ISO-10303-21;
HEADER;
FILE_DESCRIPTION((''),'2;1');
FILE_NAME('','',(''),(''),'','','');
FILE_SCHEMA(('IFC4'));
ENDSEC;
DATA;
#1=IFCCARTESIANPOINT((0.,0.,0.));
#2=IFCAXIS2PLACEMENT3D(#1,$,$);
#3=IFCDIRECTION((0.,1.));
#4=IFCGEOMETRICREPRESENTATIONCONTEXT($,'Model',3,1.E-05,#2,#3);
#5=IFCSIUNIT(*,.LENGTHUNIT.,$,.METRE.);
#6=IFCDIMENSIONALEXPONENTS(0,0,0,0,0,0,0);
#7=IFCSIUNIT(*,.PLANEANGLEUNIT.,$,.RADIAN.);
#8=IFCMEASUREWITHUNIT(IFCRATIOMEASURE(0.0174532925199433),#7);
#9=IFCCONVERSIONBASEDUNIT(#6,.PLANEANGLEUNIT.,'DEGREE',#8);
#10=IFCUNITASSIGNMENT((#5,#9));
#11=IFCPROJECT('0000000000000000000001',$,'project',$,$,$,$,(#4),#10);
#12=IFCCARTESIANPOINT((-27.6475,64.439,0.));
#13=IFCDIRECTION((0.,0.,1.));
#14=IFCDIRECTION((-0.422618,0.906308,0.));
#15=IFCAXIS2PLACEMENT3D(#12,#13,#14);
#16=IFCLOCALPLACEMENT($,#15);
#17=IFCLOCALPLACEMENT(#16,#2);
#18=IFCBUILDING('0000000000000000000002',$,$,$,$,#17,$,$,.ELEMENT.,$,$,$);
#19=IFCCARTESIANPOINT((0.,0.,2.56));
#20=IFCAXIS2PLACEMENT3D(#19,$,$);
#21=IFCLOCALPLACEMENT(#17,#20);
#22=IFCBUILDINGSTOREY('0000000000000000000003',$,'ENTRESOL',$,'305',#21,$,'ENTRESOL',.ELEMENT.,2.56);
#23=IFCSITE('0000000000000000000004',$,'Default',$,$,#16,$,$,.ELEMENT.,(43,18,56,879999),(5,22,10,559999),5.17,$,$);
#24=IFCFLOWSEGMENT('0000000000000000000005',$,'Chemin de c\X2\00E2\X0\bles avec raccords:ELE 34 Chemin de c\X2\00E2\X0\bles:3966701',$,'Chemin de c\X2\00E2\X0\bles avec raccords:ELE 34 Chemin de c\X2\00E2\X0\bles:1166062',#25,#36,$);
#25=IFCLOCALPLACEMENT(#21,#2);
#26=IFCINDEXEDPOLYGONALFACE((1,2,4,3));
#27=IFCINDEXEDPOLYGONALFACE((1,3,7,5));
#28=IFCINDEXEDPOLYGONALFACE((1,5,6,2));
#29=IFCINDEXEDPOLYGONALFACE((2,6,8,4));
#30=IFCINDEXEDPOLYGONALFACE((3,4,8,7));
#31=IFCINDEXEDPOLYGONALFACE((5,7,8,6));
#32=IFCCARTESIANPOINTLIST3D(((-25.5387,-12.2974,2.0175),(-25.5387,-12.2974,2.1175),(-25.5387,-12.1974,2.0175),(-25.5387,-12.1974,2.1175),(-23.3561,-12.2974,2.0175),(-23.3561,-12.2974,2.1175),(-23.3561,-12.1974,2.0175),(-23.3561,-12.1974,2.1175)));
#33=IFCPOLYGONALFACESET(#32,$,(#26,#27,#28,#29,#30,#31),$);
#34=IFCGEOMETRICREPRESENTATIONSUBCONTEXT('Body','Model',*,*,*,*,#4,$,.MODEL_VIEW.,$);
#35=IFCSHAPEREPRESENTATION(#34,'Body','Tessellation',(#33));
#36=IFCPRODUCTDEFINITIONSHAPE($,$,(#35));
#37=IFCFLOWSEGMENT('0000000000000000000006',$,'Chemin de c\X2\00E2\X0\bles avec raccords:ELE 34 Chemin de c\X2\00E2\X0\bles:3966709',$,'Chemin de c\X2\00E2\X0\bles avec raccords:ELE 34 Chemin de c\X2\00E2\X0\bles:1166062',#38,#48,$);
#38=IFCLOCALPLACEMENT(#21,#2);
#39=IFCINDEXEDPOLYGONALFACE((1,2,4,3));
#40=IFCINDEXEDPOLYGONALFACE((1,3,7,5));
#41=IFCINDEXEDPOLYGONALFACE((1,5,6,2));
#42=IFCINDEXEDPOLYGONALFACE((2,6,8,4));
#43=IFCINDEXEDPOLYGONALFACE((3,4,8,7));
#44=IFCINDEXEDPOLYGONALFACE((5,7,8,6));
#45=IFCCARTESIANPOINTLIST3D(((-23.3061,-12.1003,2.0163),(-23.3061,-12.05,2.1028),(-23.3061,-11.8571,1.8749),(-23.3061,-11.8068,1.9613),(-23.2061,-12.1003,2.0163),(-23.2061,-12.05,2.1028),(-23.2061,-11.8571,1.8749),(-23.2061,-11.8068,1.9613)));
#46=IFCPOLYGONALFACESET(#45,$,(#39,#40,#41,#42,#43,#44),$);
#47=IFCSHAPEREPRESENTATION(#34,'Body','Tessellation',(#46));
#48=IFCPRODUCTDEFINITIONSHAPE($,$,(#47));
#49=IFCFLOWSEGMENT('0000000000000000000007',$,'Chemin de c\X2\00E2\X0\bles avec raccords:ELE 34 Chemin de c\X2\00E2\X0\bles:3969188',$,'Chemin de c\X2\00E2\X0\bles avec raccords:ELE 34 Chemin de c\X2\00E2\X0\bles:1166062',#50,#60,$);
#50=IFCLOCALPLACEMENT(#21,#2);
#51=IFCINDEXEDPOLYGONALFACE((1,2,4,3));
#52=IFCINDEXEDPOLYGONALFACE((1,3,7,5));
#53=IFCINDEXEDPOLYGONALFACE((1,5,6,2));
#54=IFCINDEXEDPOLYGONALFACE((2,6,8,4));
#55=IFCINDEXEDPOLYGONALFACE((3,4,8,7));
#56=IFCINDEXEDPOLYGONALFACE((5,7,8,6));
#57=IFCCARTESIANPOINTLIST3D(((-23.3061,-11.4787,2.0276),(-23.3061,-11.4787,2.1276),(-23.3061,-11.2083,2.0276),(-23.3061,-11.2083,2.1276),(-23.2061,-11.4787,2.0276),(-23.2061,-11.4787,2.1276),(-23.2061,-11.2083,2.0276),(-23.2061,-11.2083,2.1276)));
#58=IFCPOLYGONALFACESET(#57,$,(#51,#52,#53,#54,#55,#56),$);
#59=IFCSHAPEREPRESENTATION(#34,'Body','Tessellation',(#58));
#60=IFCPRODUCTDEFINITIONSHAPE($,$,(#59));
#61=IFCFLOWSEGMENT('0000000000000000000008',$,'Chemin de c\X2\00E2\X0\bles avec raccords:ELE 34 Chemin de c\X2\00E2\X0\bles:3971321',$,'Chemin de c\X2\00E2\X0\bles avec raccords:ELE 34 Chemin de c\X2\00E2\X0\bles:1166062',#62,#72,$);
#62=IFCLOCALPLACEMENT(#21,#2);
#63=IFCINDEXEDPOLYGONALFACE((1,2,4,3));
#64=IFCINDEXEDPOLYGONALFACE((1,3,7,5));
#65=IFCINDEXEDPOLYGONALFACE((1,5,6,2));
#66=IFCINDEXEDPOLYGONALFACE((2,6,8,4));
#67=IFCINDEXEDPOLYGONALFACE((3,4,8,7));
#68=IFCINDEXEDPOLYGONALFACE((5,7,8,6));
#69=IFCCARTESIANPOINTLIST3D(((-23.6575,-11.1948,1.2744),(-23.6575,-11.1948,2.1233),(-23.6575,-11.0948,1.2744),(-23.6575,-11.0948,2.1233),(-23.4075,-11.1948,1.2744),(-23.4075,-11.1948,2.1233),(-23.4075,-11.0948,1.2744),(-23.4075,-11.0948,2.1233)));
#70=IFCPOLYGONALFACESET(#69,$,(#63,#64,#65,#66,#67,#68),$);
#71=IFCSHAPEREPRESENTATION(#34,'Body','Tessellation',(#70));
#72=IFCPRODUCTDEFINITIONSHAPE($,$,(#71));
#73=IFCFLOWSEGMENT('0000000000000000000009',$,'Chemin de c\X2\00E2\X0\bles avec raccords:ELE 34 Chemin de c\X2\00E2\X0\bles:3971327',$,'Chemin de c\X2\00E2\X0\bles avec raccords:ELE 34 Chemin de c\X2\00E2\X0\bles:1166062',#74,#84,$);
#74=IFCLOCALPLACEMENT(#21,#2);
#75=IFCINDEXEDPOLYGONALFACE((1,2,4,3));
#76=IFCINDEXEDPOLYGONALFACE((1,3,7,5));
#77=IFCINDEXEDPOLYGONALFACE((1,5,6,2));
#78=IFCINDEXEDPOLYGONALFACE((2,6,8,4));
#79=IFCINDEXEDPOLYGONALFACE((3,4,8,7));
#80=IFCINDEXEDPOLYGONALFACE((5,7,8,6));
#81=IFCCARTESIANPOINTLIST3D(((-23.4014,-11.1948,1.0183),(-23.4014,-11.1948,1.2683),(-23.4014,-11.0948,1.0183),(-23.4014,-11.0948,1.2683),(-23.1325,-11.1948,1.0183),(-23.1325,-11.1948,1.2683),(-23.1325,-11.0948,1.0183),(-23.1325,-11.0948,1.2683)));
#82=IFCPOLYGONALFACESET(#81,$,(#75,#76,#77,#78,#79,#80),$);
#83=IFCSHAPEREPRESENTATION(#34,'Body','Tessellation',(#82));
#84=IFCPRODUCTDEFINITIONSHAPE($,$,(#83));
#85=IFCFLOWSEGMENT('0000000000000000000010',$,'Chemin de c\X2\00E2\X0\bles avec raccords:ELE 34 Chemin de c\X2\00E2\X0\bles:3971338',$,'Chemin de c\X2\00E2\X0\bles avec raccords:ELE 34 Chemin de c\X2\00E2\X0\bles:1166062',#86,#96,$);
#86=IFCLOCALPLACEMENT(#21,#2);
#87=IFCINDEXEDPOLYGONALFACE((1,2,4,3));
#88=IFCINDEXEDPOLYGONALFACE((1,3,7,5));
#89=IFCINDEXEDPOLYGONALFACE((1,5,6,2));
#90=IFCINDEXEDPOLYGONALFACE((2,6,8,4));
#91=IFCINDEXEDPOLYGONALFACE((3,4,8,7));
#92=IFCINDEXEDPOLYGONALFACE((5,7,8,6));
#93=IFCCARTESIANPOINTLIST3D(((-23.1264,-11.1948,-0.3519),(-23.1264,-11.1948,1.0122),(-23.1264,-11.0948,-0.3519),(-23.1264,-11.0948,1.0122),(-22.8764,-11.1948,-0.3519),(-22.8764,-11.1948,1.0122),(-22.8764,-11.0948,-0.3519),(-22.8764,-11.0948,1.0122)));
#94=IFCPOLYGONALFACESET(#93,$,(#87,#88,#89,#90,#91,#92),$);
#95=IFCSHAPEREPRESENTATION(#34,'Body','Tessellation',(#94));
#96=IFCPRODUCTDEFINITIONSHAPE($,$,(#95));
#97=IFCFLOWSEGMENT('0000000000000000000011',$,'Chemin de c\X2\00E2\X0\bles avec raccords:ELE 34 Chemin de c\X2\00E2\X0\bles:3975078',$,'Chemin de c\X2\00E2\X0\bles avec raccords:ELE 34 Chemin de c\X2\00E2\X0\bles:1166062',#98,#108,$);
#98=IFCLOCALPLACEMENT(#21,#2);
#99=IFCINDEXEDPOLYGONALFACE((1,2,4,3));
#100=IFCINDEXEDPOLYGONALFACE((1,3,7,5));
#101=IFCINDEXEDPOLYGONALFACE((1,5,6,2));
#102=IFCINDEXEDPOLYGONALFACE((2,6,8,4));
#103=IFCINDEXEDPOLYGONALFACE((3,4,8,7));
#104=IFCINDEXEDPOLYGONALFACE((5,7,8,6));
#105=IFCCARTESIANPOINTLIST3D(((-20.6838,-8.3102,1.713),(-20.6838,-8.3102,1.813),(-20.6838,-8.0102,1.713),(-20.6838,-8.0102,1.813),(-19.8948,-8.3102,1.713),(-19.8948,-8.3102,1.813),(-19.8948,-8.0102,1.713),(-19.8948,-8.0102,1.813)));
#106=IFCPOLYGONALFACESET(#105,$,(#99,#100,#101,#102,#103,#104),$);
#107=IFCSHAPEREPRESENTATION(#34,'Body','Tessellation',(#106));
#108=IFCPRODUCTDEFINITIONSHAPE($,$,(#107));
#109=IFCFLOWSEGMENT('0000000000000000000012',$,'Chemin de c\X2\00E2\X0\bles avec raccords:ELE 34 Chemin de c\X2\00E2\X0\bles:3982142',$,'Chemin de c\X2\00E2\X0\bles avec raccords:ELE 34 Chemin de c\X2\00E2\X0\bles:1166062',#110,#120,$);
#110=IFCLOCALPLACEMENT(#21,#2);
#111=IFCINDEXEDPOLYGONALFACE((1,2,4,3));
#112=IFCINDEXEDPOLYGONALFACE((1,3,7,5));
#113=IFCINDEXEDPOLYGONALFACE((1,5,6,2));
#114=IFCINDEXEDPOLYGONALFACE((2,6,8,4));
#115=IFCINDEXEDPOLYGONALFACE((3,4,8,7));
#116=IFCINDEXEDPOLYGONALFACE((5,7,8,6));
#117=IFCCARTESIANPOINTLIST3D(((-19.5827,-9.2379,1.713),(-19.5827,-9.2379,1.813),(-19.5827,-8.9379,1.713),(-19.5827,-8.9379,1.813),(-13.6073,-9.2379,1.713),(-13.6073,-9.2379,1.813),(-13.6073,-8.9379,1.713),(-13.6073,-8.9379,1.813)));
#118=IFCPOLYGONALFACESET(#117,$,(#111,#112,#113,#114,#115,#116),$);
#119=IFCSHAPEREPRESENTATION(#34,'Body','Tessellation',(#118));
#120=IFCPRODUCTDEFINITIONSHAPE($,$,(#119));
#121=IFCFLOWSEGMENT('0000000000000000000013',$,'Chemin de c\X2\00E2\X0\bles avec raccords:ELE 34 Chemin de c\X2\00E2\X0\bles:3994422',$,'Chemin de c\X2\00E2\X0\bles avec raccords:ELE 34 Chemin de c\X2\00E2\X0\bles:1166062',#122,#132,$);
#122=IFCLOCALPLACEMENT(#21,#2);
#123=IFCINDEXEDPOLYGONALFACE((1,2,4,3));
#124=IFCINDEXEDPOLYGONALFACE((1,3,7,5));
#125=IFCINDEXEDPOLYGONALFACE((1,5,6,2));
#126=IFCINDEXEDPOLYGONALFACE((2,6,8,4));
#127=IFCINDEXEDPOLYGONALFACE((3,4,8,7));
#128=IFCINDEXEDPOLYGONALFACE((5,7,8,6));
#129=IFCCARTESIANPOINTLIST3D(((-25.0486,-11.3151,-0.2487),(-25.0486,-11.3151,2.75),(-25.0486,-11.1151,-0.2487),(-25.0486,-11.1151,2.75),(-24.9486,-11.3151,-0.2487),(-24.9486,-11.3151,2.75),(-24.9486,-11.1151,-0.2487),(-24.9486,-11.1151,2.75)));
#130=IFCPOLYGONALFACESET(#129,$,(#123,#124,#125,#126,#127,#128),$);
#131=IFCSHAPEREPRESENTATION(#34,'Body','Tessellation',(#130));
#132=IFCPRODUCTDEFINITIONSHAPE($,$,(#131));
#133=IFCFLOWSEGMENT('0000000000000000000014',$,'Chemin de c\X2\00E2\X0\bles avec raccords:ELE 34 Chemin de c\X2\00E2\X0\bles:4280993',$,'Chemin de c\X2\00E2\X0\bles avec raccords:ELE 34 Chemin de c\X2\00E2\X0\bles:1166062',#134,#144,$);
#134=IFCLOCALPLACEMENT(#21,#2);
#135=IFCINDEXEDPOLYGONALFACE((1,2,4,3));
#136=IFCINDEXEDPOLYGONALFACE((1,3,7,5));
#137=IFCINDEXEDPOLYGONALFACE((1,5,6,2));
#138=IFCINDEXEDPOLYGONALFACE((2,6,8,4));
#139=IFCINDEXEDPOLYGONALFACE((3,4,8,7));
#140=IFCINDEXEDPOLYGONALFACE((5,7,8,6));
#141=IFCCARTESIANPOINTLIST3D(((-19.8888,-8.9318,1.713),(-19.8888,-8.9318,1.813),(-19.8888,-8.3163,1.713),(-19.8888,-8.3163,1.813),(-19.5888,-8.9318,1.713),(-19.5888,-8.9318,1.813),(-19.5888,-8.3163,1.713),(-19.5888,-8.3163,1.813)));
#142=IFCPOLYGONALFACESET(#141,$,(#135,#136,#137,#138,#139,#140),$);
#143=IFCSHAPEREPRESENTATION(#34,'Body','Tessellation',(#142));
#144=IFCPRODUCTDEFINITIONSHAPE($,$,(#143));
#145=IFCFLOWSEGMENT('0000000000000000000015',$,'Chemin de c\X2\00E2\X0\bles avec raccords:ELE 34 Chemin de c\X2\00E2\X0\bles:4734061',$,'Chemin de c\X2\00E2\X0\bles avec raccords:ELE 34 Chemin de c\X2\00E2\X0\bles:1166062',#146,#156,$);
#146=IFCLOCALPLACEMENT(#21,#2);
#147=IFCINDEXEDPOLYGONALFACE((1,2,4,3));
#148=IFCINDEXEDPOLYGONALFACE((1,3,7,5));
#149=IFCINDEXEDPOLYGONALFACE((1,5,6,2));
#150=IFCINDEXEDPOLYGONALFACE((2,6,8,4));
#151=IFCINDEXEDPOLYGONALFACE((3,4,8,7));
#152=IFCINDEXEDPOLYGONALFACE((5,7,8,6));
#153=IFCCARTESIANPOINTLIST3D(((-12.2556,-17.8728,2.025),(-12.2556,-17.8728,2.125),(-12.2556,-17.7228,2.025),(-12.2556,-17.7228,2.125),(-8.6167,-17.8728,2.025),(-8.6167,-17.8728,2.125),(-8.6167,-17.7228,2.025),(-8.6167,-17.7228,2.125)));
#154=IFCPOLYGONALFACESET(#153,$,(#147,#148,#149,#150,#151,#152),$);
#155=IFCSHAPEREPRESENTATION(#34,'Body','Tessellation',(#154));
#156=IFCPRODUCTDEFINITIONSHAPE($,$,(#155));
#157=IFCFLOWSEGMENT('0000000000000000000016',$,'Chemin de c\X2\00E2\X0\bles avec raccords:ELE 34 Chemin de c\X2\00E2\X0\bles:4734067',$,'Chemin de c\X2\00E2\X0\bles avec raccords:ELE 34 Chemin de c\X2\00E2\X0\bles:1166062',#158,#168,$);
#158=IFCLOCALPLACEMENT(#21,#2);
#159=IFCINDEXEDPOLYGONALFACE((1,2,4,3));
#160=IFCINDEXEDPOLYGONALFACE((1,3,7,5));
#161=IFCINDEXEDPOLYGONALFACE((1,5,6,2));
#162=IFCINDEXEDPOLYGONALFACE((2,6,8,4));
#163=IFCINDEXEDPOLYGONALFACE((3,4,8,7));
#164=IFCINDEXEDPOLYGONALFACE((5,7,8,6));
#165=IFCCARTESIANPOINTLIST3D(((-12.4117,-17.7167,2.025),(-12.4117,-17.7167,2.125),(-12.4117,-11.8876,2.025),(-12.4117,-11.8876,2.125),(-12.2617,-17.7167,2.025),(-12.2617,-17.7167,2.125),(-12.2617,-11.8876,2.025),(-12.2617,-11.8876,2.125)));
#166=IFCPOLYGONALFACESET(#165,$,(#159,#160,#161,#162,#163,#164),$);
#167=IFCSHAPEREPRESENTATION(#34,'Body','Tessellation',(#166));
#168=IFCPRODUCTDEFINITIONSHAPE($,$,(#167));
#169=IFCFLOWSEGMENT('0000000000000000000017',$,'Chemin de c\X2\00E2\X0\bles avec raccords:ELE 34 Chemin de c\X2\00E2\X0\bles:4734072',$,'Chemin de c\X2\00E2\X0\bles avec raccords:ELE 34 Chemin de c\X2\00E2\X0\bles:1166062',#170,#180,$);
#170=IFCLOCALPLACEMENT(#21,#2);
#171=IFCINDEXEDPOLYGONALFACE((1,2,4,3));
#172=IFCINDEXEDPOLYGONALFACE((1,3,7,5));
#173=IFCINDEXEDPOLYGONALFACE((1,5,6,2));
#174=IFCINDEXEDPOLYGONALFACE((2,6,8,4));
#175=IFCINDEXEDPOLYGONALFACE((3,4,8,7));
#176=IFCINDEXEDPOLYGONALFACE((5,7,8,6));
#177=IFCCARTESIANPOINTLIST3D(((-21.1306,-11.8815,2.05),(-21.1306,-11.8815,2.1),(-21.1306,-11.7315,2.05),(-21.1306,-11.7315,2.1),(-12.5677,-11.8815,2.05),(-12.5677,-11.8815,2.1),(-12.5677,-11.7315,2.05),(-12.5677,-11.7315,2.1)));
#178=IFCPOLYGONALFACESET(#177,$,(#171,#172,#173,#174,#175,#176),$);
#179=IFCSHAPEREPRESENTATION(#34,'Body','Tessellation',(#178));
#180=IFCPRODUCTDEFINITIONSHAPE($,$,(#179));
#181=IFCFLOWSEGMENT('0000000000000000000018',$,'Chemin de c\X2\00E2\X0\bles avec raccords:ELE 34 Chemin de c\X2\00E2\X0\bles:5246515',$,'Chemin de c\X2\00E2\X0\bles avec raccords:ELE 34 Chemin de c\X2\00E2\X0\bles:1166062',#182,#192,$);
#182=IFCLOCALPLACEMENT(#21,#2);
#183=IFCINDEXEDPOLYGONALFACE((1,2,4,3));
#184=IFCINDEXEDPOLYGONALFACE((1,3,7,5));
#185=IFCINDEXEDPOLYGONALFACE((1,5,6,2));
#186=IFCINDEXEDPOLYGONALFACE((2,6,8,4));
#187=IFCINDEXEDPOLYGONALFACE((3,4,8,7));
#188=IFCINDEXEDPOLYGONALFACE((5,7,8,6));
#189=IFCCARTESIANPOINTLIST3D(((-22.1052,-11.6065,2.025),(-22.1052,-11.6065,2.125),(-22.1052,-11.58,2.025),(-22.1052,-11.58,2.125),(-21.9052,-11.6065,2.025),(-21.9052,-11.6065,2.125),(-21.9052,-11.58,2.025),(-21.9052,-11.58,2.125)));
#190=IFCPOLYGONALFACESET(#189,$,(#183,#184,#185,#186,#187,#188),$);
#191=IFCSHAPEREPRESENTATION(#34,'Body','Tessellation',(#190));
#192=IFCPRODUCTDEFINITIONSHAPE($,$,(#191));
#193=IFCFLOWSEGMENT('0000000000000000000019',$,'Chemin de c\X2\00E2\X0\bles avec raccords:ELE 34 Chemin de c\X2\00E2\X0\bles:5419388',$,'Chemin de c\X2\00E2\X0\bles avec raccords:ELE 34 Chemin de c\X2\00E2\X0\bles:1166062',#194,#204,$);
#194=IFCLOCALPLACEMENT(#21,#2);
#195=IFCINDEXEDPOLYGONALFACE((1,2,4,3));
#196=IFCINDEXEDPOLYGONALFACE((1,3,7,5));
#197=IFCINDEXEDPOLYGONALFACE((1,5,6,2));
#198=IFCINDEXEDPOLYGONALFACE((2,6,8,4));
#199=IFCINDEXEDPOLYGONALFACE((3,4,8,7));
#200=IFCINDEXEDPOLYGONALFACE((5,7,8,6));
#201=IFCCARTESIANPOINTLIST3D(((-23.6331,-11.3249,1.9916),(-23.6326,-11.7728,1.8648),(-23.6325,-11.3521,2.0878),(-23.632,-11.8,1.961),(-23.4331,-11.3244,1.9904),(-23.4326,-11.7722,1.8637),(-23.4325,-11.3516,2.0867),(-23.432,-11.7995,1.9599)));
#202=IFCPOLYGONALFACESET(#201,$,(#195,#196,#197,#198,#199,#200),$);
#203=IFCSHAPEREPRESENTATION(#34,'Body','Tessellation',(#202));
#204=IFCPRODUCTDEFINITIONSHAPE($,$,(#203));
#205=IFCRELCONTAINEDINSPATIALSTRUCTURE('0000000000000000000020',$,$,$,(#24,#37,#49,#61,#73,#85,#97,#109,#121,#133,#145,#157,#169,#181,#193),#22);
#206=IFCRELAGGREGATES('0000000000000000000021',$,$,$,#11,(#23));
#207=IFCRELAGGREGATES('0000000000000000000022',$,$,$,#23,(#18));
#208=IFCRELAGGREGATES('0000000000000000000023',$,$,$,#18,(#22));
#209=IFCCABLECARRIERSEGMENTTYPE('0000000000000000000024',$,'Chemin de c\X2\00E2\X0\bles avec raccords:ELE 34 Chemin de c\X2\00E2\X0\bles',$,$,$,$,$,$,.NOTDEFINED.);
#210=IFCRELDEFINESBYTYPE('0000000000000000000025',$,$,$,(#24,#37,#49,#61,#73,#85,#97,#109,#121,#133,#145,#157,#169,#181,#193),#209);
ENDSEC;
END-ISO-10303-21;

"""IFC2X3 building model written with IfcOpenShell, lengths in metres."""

from ifc_helpers import new_model, entity, si_unit, converted_unit, direction, frame, frame_2d, origin, origin_2d_with_axis, place, context, subcontext, project, spatial, rectangle, extrude, type_object, element, save


model = new_model("IFC2X3")

# Units and contexts
model_context = context("Model", 3, precision=1e-05, world=origin(), true_north=direction((0.0, 1.0)))
body_context = subcontext(model_context, "Body", "Model", "MODEL_VIEW")
ifc_project = project(units=[si_unit("LENGTHUNIT", "METRE"), converted_unit("PLANEANGLEUNIT", "DEGREE", entity("IfcRatioMeasure", 0.0174532925199433), si_unit("PLANEANGLEUNIT", "RADIAN"), dimensions=[0, 0, 0, 0, 0, 0, 0])], contexts=[model_context])

# Site, building, storey
site_placement = place(None, frame((-27.6475, 64.439, 0.0), z_axis=(0.0, 0.0, 1.0), x_axis=(-0.422618, 0.906308, 0.0)))
site = spatial("IfcSite", under=ifc_project, at=site_placement, Name="Default", CompositionType="ELEMENT", RefLatitude=(43, 18, 56, 879999), RefLongitude=(5, 22, 10, 559999), RefElevation=5.17)
building_placement = place(site_placement, origin())
building = spatial("IfcBuilding", under=site, at=building_placement, CompositionType="ELEMENT")
storey_placement = place(building_placement, frame((0.0, 0.0, 2.56)))
storey = spatial("IfcBuildingStorey", under=building, at=storey_placement, Name="ENTRESOL", ObjectType="305", LongName="ENTRESOL", CompositionType="ELEMENT", Elevation=2.56)

# Flow segments
cable_carrier_segment_type = type_object("IfcCableCarrierSegmentType", Name="Chemin de câbles avec raccords:ELE 34 Chemin de câbles", PredefinedType="NOTDEFINED")
flow_segment_1_placement = place(storey_placement, origin())
element("IfcFlowSegment", 1, at=flow_segment_1_placement, inside=storey, type_object=cable_carrier_segment_type, Name="Chemin de câbles avec raccords:ELE 34 Chemin de câbles:3966701", ObjectType="Chemin de câbles avec raccords:ELE 34 Chemin de câbles:1166062", context=body_context, shape_type="SweptSolid", body=[
    extrude(rectangle(XDim=2.1825, YDim=0.1, at=frame_2d((0.0, 0.0), x_axis=(1.0, 0.0))), frame((-24.4474, -12.2474, 2.0175)), (0.0, 0.0, 1.0), 0.1),
])
flow_segment_2_placement = place(storey_placement, origin())
element("IfcFlowSegment", 2, at=flow_segment_2_placement, inside=storey, type_object=cable_carrier_segment_type, Name="Chemin de câbles avec raccords:ELE 34 Chemin de câbles:3966709", ObjectType="Chemin de câbles avec raccords:ELE 34 Chemin de câbles:1166062", context=body_context, shape_type="SweptSolid", body=[
    extrude(rectangle(XDim=0.1, YDim=0.2813, at=frame_2d((0.0, 0.0), x_axis=(0.0, 1.0))), frame((-23.3061, -11.9535, 1.9888), z_axis=(1.0, 0.0, 0.0), x_axis=(0.0, 0.864443, -0.50273)), (0.0, 0.0, 1.0), 0.1),
])
flow_segment_3_placement = place(storey_placement, origin())
element("IfcFlowSegment", 3, at=flow_segment_3_placement, inside=storey, type_object=cable_carrier_segment_type, Name="Chemin de câbles avec raccords:ELE 34 Chemin de câbles:3969188", ObjectType="Chemin de câbles avec raccords:ELE 34 Chemin de câbles:1166062", context=body_context, shape_type="SweptSolid", body=[
    extrude(rectangle(XDim=0.1, YDim=0.1, at=frame_2d((0.0, 0.0), x_axis=(0.0, 1.0))), frame((-23.2561, -11.4787, 2.0776), z_axis=(0.0, 1.0, 0.0), x_axis=(-1.0, 0.0, 0.000174)), (0.0, 0.0, 1.0), 0.2704),
])
flow_segment_4_placement = place(storey_placement, origin())
element("IfcFlowSegment", 4, at=flow_segment_4_placement, inside=storey, type_object=cable_carrier_segment_type, Name="Chemin de câbles avec raccords:ELE 34 Chemin de câbles:3971321", ObjectType="Chemin de câbles avec raccords:ELE 34 Chemin de câbles:1166062", context=body_context, shape_type="SweptSolid", body=[
    extrude(rectangle(XDim=0.25, YDim=0.1, at=origin_2d_with_axis()), frame((-23.5325, -11.1448, 1.2744)), (0.0, 0.0, 1.0), 0.8489),
])
flow_segment_5_placement = place(storey_placement, origin())
element("IfcFlowSegment", 5, at=flow_segment_5_placement, inside=storey, type_object=cable_carrier_segment_type, Name="Chemin de câbles avec raccords:ELE 34 Chemin de câbles:3971327", ObjectType="Chemin de câbles avec raccords:ELE 34 Chemin de câbles:1166062", context=body_context, shape_type="SweptSolid", body=[
    extrude(rectangle(XDim=0.2689, YDim=0.1, at=frame_2d((0.0, 0.0), x_axis=(1.0, 0.0))), frame((-23.2669, -11.1448, 1.0183), z_axis=(0.0, 0.0, 1.0), x_axis=(-1.0, 0.0, 0.0)), (0.0, 0.0, 1.0), 0.25),
])
flow_segment_6_placement = place(storey_placement, origin())
element("IfcFlowSegment", 6, at=flow_segment_6_placement, inside=storey, type_object=cable_carrier_segment_type, Name="Chemin de câbles avec raccords:ELE 34 Chemin de câbles:3971338", ObjectType="Chemin de câbles avec raccords:ELE 34 Chemin de câbles:1166062", context=body_context, shape_type="SweptSolid", body=[
    extrude(rectangle(XDim=0.25, YDim=0.1, at=origin_2d_with_axis()), frame((-23.0014, -11.1448, -0.3519)), (0.0, 0.0, 1.0), 1.3642),
])
flow_segment_7_placement = place(storey_placement, origin())
element("IfcFlowSegment", 7, at=flow_segment_7_placement, inside=storey, type_object=cable_carrier_segment_type, Name="Chemin de câbles avec raccords:ELE 34 Chemin de câbles:3975078", ObjectType="Chemin de câbles avec raccords:ELE 34 Chemin de câbles:1166062", context=body_context, shape_type="SweptSolid", body=[
    extrude(rectangle(XDim=0.7889, YDim=0.3, at=frame_2d((0.0, 0.0), x_axis=(1.0, 0.0))), frame((-20.2893, -8.1602, 1.713), z_axis=(0.0, 0.0, 1.0), x_axis=(-1.0, 0.0, 0.0)), (0.0, 0.0, 1.0), 0.1),
])
flow_segment_8_placement = place(storey_placement, origin())
element("IfcFlowSegment", 8, at=flow_segment_8_placement, inside=storey, type_object=cable_carrier_segment_type, Name="Chemin de câbles avec raccords:ELE 34 Chemin de câbles:3982142", ObjectType="Chemin de câbles avec raccords:ELE 34 Chemin de câbles:1166062", context=body_context, shape_type="SweptSolid", body=[
    extrude(rectangle(XDim=5.9753, YDim=0.3, at=frame_2d((0.0, 0.0), x_axis=(1.0, 0.0))), frame((-16.595, -9.0879, 1.713)), (0.0, 0.0, 1.0), 0.1),
])
flow_segment_9_placement = place(storey_placement, origin())
element("IfcFlowSegment", 9, at=flow_segment_9_placement, inside=storey, type_object=cable_carrier_segment_type, Name="Chemin de câbles avec raccords:ELE 34 Chemin de câbles:3994422", ObjectType="Chemin de câbles avec raccords:ELE 34 Chemin de câbles:1166062", context=body_context, shape_type="SweptSolid", body=[
    extrude(rectangle(XDim=0.1, YDim=0.2, at=origin_2d_with_axis()), frame((-24.9986, -11.2151, -0.2487)), (0.0, 0.0, 1.0), 2.9987),
])
flow_segment_10_placement = place(storey_placement, origin())
element("IfcFlowSegment", 10, at=flow_segment_10_placement, inside=storey, type_object=cable_carrier_segment_type, Name="Chemin de câbles avec raccords:ELE 34 Chemin de câbles:4280993", ObjectType="Chemin de câbles avec raccords:ELE 34 Chemin de câbles:1166062", context=body_context, shape_type="SweptSolid", body=[
    extrude(rectangle(XDim=0.6155, YDim=0.3, at=origin_2d_with_axis()), frame((-19.7388, -8.6241, 1.713), z_axis=(0.0, 0.000011, 1.0), x_axis=(0.0, 1.0, -0.000011)), (0.0, 0.0, 1.0), 0.1),
])
flow_segment_11_placement = place(storey_placement, origin())
element("IfcFlowSegment", 11, at=flow_segment_11_placement, inside=storey, type_object=cable_carrier_segment_type, Name="Chemin de câbles avec raccords:ELE 34 Chemin de câbles:4734061", ObjectType="Chemin de câbles avec raccords:ELE 34 Chemin de câbles:1166062", context=body_context, shape_type="SweptSolid", body=[
    extrude(rectangle(XDim=3.6389, YDim=0.15, at=frame_2d((0.0, 0.0), x_axis=(1.0, 0.0))), frame((-10.4361, -17.7978, 2.025), z_axis=(0.0, 0.0, 1.0), x_axis=(-1.0, 0.0, 0.0)), (0.0, 0.0, 1.0), 0.1),
])
flow_segment_12_placement = place(storey_placement, origin())
element("IfcFlowSegment", 12, at=flow_segment_12_placement, inside=storey, type_object=cable_carrier_segment_type, Name="Chemin de câbles avec raccords:ELE 34 Chemin de câbles:4734067", ObjectType="Chemin de câbles avec raccords:ELE 34 Chemin de câbles:1166062", context=body_context, shape_type="SweptSolid", body=[
    extrude(rectangle(XDim=5.8292, YDim=0.15, at=frame_2d((0.0, 0.0), x_axis=(1.0, 0.0))), frame((-12.3367, -14.8022, 2.025), z_axis=(0.0, 0.0, 1.0), x_axis=(0.0, 1.0, 0.0)), (0.0, 0.0, 1.0), 0.1),
])
flow_segment_13_placement = place(storey_placement, origin())
element("IfcFlowSegment", 13, at=flow_segment_13_placement, inside=storey, type_object=cable_carrier_segment_type, Name="Chemin de câbles avec raccords:ELE 34 Chemin de câbles:4734072", ObjectType="Chemin de câbles avec raccords:ELE 34 Chemin de câbles:1166062", context=body_context, shape_type="SweptSolid", body=[
    extrude(rectangle(XDim=8.5629, YDim=0.15, at=frame_2d((0.0, 0.0), x_axis=(1.0, 0.0))), frame((-16.8492, -11.8065, 2.05), z_axis=(0.0, 0.0, 1.0), x_axis=(-1.0, 0.0, 0.0)), (0.0, 0.0, 1.0), 0.05),
])
flow_segment_14_placement = place(storey_placement, origin())
element("IfcFlowSegment", 14, at=flow_segment_14_placement, inside=storey, type_object=cable_carrier_segment_type, Name="Chemin de câbles avec raccords:ELE 34 Chemin de câbles:5246515", ObjectType="Chemin de câbles avec raccords:ELE 34 Chemin de câbles:1166062", context=body_context, shape_type="SweptSolid", body=[
    extrude(rectangle(XDim=0.0264, YDim=0.2, at=frame_2d((0.0, 0.0), x_axis=(1.0, 0.0))), frame((-22.0052, -11.5933, 2.025), z_axis=(0.0, 0.0, 1.0), x_axis=(0.0, 1.0, 0.0)), (0.0, 0.0, 1.0), 0.1),
])
flow_segment_15_placement = place(storey_placement, origin())
element("IfcFlowSegment", 15, at=flow_segment_15_placement, inside=storey, type_object=cable_carrier_segment_type, Name="Chemin de câbles avec raccords:ELE 34 Chemin de câbles:5419388", ObjectType="Chemin de câbles avec raccords:ELE 34 Chemin de câbles:1166062", context=body_context, shape_type="SweptSolid", body=[
    extrude(rectangle(XDim=0.1, YDim=0.2, at=frame_2d((0.0, 0.0), x_axis=(1.0, 0.0))), frame((-23.5323, -11.7861, 1.9124), z_axis=(-0.001124, 0.962194, 0.272363), x_axis=(0.006295, -0.272351, 0.962177)), (0.0, 0.0, 1.0), 0.4655),
])

save(model, "model.ifc")
